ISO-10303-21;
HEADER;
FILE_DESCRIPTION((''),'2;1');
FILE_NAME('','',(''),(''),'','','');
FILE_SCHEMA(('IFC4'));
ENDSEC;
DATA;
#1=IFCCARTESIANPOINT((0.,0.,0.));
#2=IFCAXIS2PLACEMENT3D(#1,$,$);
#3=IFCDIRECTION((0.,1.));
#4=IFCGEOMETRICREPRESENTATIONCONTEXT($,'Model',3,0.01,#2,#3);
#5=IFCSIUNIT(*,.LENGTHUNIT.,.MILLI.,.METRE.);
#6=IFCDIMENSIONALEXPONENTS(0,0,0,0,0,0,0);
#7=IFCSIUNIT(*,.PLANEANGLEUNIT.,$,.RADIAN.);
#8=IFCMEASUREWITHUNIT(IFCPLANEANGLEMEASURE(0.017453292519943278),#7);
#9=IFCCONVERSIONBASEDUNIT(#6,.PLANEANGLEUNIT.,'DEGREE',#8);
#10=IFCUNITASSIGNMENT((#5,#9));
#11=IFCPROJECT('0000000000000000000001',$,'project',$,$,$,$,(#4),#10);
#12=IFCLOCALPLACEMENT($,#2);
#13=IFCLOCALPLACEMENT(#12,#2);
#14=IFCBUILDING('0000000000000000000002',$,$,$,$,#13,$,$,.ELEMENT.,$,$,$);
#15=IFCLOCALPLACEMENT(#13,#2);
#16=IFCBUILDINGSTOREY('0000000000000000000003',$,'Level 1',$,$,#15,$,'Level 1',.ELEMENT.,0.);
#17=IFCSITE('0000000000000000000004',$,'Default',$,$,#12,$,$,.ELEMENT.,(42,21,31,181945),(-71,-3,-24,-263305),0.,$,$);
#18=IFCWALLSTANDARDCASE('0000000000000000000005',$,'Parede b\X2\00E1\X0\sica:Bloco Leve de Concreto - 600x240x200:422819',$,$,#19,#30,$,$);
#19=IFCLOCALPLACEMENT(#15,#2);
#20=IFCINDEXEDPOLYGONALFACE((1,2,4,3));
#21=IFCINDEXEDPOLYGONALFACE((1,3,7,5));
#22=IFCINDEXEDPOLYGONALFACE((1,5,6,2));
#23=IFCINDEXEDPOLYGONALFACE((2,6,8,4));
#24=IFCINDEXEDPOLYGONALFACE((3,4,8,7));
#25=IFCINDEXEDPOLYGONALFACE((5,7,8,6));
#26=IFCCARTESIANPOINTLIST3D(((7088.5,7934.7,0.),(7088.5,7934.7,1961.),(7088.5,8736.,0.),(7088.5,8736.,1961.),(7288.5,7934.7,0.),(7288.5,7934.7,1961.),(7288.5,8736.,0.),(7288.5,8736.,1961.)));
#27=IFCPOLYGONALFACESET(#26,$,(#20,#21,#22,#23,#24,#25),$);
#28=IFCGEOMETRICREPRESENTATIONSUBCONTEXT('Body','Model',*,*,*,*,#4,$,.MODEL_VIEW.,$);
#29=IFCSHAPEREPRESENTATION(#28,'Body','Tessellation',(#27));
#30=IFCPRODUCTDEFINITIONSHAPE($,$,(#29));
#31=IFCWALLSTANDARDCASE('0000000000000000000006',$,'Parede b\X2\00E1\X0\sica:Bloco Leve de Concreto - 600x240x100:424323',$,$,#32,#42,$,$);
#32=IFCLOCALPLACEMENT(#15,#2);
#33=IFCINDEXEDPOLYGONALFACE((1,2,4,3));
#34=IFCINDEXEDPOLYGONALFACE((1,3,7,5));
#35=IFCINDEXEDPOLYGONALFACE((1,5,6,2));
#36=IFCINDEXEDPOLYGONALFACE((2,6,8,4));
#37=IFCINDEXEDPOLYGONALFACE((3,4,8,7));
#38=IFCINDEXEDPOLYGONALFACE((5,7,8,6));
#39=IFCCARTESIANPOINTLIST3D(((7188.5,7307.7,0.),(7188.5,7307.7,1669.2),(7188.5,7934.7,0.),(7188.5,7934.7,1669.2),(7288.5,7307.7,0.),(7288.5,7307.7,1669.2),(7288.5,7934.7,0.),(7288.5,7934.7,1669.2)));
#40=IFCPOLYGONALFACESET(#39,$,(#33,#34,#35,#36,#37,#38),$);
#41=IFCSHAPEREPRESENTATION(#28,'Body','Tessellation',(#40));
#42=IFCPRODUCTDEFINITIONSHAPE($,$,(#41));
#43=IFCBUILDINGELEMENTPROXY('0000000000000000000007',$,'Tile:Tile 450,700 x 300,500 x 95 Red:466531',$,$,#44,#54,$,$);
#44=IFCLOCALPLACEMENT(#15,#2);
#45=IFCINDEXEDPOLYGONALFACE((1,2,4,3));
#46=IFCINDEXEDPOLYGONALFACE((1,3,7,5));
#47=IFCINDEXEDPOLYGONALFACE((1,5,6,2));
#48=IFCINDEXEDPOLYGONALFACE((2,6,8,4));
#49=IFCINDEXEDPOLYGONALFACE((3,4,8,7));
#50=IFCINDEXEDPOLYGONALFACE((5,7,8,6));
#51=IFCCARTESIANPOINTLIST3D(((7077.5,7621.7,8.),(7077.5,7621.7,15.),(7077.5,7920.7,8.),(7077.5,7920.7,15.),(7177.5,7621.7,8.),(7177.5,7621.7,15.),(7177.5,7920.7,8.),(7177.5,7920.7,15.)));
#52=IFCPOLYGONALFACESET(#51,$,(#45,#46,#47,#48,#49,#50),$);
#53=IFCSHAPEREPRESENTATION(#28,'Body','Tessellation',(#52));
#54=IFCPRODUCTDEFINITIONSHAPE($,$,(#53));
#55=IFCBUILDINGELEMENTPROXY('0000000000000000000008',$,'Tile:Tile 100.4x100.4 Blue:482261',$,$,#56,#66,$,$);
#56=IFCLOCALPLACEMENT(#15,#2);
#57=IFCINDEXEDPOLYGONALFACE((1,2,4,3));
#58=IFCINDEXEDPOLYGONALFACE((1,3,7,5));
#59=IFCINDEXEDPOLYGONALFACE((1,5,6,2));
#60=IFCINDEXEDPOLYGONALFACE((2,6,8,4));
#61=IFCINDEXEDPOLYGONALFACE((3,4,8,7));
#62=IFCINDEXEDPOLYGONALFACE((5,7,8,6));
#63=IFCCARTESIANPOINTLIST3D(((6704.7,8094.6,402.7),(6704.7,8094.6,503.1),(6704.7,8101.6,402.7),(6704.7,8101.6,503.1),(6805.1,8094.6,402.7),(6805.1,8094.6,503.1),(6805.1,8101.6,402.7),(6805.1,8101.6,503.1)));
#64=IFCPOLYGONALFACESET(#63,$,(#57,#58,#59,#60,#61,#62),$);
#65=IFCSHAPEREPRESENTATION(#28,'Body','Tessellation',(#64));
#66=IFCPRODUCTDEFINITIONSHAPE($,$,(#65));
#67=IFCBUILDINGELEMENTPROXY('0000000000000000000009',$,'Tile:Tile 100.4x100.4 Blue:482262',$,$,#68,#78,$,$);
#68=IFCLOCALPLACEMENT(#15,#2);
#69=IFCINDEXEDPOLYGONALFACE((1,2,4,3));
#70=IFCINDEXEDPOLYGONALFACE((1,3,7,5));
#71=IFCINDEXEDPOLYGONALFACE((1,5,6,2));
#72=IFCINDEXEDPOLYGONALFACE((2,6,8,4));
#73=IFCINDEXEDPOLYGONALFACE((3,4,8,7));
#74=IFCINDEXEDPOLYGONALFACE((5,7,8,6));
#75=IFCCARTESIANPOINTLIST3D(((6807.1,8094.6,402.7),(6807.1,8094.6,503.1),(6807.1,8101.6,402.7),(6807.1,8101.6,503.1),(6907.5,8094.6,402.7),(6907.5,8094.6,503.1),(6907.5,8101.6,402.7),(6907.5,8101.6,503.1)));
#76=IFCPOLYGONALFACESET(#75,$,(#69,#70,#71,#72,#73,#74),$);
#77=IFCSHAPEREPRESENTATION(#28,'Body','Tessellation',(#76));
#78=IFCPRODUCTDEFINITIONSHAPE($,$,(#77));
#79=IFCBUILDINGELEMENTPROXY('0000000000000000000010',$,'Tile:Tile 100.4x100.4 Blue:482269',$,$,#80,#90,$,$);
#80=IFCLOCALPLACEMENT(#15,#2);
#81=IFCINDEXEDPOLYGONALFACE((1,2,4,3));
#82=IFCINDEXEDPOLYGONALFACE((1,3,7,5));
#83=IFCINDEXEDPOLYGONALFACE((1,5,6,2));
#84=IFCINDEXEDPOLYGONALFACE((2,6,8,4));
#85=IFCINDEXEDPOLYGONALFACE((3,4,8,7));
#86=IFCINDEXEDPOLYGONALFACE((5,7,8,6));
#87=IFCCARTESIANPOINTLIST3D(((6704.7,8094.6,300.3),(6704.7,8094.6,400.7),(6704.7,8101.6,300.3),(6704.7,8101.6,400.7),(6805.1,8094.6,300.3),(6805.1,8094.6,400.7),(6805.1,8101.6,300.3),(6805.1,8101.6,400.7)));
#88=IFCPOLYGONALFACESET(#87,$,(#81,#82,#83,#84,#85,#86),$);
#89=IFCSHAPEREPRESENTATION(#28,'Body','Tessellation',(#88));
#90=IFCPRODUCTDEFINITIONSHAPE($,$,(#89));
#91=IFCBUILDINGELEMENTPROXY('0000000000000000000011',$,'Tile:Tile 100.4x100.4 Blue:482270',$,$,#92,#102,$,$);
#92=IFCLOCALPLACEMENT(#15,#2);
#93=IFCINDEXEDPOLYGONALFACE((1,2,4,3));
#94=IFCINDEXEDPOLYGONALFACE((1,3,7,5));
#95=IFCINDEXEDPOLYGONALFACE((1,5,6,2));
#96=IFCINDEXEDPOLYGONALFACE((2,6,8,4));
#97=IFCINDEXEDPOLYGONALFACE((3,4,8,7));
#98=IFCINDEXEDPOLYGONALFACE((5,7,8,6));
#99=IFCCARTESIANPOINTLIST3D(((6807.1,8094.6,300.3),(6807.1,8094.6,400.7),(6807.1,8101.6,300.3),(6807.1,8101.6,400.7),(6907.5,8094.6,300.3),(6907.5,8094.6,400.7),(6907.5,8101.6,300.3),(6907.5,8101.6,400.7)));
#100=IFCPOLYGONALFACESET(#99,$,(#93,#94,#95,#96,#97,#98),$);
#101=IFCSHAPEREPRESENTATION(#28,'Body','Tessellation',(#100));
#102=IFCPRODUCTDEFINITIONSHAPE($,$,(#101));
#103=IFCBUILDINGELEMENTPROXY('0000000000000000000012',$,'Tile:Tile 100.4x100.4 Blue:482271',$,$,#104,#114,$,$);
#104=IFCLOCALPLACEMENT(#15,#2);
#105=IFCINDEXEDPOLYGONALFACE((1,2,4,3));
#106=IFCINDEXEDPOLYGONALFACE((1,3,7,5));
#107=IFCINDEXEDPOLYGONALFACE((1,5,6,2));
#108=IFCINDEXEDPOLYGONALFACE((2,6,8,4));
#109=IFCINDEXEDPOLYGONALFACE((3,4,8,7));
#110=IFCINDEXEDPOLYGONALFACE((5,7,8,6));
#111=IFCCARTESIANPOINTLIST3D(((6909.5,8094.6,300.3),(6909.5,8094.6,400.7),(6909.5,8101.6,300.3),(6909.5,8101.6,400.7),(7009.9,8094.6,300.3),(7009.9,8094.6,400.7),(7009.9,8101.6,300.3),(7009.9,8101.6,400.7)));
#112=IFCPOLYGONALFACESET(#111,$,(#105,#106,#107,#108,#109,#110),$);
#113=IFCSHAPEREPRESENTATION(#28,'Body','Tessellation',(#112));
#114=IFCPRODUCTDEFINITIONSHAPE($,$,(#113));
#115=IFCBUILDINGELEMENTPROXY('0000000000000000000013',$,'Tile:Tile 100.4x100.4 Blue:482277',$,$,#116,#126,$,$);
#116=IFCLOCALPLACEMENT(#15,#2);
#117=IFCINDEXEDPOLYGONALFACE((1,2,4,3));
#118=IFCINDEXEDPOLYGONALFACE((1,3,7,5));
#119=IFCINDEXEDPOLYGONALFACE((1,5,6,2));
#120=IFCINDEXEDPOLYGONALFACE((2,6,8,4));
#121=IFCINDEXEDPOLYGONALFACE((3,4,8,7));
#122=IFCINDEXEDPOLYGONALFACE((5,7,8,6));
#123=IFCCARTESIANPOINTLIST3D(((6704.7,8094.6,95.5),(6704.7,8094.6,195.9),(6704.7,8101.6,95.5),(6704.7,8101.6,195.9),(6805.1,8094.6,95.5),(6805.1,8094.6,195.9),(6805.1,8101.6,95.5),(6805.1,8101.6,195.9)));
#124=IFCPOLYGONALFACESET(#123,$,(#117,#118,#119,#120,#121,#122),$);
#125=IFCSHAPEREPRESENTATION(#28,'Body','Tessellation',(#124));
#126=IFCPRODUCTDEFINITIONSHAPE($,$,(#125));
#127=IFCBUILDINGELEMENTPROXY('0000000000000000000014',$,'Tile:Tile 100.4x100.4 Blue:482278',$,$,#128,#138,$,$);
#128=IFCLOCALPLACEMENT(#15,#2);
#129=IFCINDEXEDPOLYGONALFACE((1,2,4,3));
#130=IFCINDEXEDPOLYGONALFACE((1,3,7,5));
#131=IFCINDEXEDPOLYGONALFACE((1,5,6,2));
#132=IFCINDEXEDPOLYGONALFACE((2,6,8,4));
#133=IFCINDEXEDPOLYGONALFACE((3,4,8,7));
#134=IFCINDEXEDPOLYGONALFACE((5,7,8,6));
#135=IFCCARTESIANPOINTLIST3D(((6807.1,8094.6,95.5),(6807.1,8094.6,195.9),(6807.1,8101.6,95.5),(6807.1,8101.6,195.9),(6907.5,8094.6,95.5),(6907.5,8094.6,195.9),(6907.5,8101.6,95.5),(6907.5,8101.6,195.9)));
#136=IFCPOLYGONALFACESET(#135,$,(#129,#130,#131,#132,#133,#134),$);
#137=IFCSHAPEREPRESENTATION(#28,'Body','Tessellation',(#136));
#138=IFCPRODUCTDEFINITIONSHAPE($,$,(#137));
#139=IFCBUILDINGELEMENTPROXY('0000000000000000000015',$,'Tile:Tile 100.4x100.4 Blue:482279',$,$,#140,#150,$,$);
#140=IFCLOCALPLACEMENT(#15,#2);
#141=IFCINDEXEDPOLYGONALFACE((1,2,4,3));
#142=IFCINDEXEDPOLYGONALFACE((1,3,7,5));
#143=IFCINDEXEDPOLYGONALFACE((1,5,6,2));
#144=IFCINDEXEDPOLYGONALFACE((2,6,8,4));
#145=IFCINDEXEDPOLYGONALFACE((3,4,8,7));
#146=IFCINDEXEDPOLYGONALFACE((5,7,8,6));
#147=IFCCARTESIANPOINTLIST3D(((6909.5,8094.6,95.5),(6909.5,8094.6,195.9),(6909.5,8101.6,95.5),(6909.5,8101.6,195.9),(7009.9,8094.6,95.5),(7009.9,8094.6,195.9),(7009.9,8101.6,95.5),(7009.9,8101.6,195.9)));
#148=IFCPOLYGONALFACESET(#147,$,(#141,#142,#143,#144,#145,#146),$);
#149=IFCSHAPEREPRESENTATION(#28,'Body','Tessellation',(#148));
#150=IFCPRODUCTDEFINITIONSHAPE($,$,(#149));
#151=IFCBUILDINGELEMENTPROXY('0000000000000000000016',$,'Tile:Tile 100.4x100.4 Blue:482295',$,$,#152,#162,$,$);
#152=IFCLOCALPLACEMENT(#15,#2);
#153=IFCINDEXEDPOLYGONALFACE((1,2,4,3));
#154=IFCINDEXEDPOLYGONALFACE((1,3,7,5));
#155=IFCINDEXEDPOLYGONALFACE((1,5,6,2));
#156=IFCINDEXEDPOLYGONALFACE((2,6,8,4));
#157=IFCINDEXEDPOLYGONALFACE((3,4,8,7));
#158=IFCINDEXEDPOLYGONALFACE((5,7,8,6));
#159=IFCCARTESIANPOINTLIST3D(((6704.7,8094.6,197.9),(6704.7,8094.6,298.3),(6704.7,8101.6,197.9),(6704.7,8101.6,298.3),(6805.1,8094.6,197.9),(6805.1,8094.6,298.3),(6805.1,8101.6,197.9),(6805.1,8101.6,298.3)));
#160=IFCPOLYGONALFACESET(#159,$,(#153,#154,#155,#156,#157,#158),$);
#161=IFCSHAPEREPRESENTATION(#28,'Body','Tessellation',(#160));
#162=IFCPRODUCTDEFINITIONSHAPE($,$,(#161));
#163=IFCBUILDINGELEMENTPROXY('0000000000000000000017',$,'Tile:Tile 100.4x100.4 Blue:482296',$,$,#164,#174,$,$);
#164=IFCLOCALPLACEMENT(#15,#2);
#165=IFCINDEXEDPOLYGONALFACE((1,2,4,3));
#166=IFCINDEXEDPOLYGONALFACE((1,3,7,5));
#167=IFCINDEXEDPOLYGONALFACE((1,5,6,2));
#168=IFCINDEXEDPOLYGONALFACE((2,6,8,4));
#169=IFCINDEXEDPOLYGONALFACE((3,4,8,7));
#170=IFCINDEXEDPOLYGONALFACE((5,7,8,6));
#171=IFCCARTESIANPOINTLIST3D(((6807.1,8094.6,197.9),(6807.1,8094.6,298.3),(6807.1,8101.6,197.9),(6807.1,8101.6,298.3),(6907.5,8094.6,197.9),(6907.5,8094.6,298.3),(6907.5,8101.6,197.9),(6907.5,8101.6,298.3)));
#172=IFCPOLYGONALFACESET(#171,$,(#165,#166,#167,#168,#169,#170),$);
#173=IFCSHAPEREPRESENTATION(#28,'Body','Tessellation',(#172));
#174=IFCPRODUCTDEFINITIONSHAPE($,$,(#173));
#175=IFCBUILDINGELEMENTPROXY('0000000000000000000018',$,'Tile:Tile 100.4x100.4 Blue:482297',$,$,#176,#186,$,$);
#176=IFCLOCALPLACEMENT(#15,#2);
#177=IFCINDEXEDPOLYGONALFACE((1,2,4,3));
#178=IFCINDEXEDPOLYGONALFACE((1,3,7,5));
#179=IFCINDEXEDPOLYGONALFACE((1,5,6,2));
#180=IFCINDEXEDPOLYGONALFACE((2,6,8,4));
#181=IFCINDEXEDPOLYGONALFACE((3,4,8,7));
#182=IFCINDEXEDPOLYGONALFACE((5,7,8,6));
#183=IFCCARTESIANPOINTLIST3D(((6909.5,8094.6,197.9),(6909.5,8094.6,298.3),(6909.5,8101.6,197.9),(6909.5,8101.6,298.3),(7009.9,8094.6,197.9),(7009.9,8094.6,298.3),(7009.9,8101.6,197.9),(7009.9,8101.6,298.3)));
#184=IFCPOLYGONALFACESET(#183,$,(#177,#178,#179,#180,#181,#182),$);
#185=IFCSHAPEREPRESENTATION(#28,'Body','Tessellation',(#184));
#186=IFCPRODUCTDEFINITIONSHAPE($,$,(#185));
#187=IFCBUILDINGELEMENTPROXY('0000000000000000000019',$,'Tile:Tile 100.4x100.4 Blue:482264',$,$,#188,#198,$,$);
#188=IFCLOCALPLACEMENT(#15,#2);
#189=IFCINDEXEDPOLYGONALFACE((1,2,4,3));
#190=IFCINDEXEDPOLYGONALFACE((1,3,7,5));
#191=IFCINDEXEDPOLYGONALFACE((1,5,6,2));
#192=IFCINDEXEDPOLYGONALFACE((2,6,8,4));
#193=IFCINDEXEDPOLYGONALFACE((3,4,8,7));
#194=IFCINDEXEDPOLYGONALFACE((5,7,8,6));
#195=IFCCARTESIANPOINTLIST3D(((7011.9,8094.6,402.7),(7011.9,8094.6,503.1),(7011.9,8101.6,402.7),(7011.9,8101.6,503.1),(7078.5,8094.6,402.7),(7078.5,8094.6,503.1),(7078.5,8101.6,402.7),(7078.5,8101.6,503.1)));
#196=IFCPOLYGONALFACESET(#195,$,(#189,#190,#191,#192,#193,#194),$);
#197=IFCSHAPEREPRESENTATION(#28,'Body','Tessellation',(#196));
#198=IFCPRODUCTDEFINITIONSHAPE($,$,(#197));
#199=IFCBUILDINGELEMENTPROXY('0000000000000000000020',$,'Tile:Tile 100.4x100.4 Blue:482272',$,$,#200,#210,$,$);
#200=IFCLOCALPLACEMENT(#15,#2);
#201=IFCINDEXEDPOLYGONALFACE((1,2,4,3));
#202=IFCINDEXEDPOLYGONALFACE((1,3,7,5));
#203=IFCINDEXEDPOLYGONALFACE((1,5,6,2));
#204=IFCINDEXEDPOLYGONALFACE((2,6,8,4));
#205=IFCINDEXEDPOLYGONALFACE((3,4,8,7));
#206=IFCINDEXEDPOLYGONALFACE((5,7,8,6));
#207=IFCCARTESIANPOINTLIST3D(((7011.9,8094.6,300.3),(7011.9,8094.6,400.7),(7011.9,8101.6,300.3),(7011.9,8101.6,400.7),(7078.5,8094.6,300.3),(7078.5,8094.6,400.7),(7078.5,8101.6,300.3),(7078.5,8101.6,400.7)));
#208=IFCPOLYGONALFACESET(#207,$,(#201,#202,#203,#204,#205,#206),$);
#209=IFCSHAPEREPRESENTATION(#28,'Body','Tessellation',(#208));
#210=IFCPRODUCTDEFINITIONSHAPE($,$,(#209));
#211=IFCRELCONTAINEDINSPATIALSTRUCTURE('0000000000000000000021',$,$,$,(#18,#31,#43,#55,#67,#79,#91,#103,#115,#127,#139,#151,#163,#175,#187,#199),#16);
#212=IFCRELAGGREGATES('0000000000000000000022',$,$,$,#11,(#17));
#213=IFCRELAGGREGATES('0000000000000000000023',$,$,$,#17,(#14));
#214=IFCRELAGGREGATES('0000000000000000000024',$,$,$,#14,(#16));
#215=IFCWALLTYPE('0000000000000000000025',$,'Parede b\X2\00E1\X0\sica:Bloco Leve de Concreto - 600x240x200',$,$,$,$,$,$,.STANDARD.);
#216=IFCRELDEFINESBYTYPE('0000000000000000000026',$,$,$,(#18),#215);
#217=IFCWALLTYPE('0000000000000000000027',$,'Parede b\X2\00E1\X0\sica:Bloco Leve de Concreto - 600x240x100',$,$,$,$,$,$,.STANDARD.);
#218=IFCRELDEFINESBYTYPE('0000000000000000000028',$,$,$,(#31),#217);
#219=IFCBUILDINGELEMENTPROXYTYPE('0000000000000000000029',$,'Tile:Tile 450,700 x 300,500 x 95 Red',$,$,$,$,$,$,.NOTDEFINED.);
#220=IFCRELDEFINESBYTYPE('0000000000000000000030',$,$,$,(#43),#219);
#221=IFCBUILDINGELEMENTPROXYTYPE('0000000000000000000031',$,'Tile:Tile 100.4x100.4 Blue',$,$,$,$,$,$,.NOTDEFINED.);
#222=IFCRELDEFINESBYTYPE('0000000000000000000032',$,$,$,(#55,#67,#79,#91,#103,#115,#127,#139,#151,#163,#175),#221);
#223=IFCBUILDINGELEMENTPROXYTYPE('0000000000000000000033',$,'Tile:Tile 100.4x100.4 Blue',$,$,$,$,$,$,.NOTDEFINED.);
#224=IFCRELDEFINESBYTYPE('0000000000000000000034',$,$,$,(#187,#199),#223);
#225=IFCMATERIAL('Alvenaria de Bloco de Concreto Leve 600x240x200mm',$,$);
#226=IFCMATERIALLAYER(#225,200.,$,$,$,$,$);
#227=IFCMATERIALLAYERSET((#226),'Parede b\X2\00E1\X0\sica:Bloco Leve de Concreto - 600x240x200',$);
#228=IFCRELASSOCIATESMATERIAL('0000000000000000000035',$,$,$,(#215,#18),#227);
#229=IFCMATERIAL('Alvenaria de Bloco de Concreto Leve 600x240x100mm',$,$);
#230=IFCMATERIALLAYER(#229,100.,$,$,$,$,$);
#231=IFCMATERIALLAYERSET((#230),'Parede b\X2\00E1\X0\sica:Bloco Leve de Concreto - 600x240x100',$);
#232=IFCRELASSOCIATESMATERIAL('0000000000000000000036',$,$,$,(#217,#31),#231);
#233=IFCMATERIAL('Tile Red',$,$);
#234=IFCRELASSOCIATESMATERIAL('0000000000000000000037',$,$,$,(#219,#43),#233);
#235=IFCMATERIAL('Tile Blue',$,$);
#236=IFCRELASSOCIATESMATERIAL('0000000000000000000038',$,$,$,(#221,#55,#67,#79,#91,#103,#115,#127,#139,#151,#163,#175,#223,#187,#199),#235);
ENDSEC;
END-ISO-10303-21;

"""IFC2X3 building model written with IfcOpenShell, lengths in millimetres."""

from ifc_helpers import new_model, entity, si_unit, converted_unit, direction, frame, frame_2d, origin, origin_2d_with_axis, place, context, subcontext, project, spatial, rectangle, extrude, source, transform, mapped, material, layer, layer_set, layer_usage, type_object, type_shapes, element, save


model = new_model("IFC2X3")

# Units and contexts
model_context = context("Model", 3, precision=0.01, world=origin(), true_north=direction((0.0, 1.0)))
body_context = subcontext(model_context, "Body", "Model", "MODEL_VIEW")
ifc_project = project(units=[si_unit("LENGTHUNIT", "METRE", prefix="MILLI"), converted_unit("PLANEANGLEUNIT", "DEGREE", entity("IfcPlaneAngleMeasure", 0.017453292519943278), si_unit("PLANEANGLEUNIT", "RADIAN"), dimensions=[0, 0, 0, 0, 0, 0, 0])], contexts=[model_context])

# Site, building, storey
site_placement = place(None, origin())
site = spatial("IfcSite", under=ifc_project, at=site_placement, Name="Default", CompositionType="ELEMENT", RefLatitude=(42, 21, 31, 181945), RefLongitude=(-71, -3, -24, -263305), RefElevation=0.0)
building_placement = place(site_placement, origin())
building = spatial("IfcBuilding", under=site, at=building_placement, CompositionType="ELEMENT")
storey_placement = place(building_placement, origin())
storey = spatial("IfcBuildingStorey", under=building, at=storey_placement, Name="Level 1", LongName="Level 1", CompositionType="ELEMENT", Elevation=0.0)

# Walls
ifc_material_1 = material(Name="Alvenaria de Bloco de Concreto Leve 600x240x200mm")
ifc_layer_1 = layer(ifc_material_1, 200.0)
ifc_layer_set_1 = layer_set([ifc_layer_1], Name="Parede básica:Bloco Leve de Concreto - 600x240x200")
ifc_layer_usage_1 = layer_usage(ifc_layer_set_1, "AXIS2", "NEGATIVE", 100.0)
wall_type_1 = type_object("IfcWallType", Name="Parede básica:Bloco Leve de Concreto - 600x240x200", PredefinedType="STANDARD", material=ifc_layer_set_1)
wall_1_placement = place(storey_placement, frame((7188.5, 8736.0, 0.0), z_axis=(0.0, 0.0, 1.0), x_axis=(0.0, -1.0, 0.0)))
element("IfcWallStandardCase", 1, at=wall_1_placement, inside=storey, type_object=wall_type_1, material=ifc_layer_usage_1, Name="Parede básica:Bloco Leve de Concreto - 600x240x200:422819", context=body_context, shape_type="SweptSolid", body=[
    extrude(rectangle(XDim=801.4, YDim=200.0, at=frame_2d((400.7, 0.0), x_axis=(-1.0, 0.0))), origin(), (0.0, 0.0, 1.0), 1961.0),
])
ifc_material_2 = material(Name="Alvenaria de Bloco de Concreto Leve 600x240x100mm")
ifc_layer_2 = layer(ifc_material_2, 100.0)
ifc_layer_set_2 = layer_set([ifc_layer_2], Name="Parede básica:Bloco Leve de Concreto - 600x240x100")
ifc_layer_usage_2 = layer_usage(ifc_layer_set_2, "AXIS2", "NEGATIVE", 50.0)
wall_type_2 = type_object("IfcWallType", Name="Parede básica:Bloco Leve de Concreto - 600x240x100", PredefinedType="STANDARD", material=ifc_layer_set_2)
wall_2_placement = place(storey_placement, frame((7238.5, 7934.7, 0.0), z_axis=(0.0, 0.0, 1.0), x_axis=(0.0, -1.0, 0.0)))
element("IfcWallStandardCase", 2, at=wall_2_placement, inside=storey, type_object=wall_type_2, material=ifc_layer_usage_2, Name="Parede básica:Bloco Leve de Concreto - 600x240x100:424323", context=body_context, shape_type="SweptSolid", body=[
    extrude(rectangle(XDim=627.0, YDim=100.0, at=frame_2d((313.5, 0.0), x_axis=(-1.0, 0.0))), origin(), (0.0, 0.0, 1.0), 1669.2),
])

# Building element proxies
ifc_material_3 = material(Name="Tile Red")
building_element_proxy_type_1 = type_object("IfcBuildingElementProxyType", Name="Tile:Tile 450,700 x 300,500 x 95 Red", PredefinedType="NOTDEFINED", material=ifc_material_3)
shared_shape_1 = source(origin(), body_context, "Body", "SweptSolid", [
    extrude(rectangle(XDim=100.0, YDim=299.0, at=origin_2d_with_axis()), frame((-50.0, -149.5, 0.0), z_axis=(0.0, 0.0, 1.0), x_axis=(-1.0, 0.0, 0.0)), (0.0, 0.0, 1.0), 7.0),
])
type_shapes(building_element_proxy_type_1, [shared_shape_1])
proxy_1_placement = place(storey_placement, frame((7177.5, 7920.7, 8.0)))
element("IfcBuildingElementProxy", 3, at=proxy_1_placement, inside=storey, type_object=building_element_proxy_type_1, material=ifc_material_3, Name="Tile:Tile 450,700 x 300,500 x 95 Red:466531", context=body_context, shape_type="MappedRepresentation", body=[
    mapped(shared_shape_1, transform((0.0, 0.0, 0.0), scale=1.0)),
])
ifc_material_4 = material(Name="Tile Blue")
building_element_proxy_type_2 = type_object("IfcBuildingElementProxyType", Name="Tile:Tile 100.4x100.4 Blue", PredefinedType="NOTDEFINED", material=ifc_material_4)
shared_shape_2 = source(origin(), body_context, "Body", "SweptSolid", [
    extrude(rectangle(XDim=100.4, YDim=100.4, at=origin_2d_with_axis()), frame((-50.2, -50.2, 0.0), z_axis=(0.0, 0.0, 1.0), x_axis=(0.0, -1.0, 0.0)), (0.0, 0.0, 1.0), 7.0),
])
type_shapes(building_element_proxy_type_2, [shared_shape_2])
for number, where, z_axis, x_axis, name in (
    (4, (6704.7, 8101.6, 402.7), (0.0, -1.0, 0.0), (-1.0, 0.0, 0.0), "Tile:Tile 100.4x100.4 Blue:482261"),
    (5, (6807.1, 8101.6, 402.7), (0.0, -1.0, 0.0), (-1.0, 0.0, 0.0), "Tile:Tile 100.4x100.4 Blue:482262"),
    (6, (6704.7, 8101.6, 300.3), (0.0, -1.0, 0.0), (-1.0, 0.0, 0.0), "Tile:Tile 100.4x100.4 Blue:482269"),
    (7, (6807.1, 8101.6, 300.3), (0.0, -1.0, 0.0), (-1.0, 0.0, 0.0), "Tile:Tile 100.4x100.4 Blue:482270"),
    (8, (6909.5, 8101.6, 300.3), (0.0, -1.0, 0.0), (-1.0, 0.0, 0.0), "Tile:Tile 100.4x100.4 Blue:482271"),
    (9, (6704.7, 8101.6, 95.5), (0.0, -1.0, 0.0), (-1.0, 0.0, 0.0), "Tile:Tile 100.4x100.4 Blue:482277"),
    (10, (6807.1, 8101.6, 95.5), (0.0, -1.0, 0.0), (-1.0, 0.0, 0.0), "Tile:Tile 100.4x100.4 Blue:482278"),
    (11, (6909.5, 8101.6, 95.5), (0.0, -1.0, 0.0), (-1.0, 0.0, 0.0), "Tile:Tile 100.4x100.4 Blue:482279"),
    (12, (6704.7, 8101.6, 197.9), (0.0, -1.0, 0.0), (-1.0, 0.0, 0.0), "Tile:Tile 100.4x100.4 Blue:482295"),
    (13, (6807.1, 8101.6, 197.9), (0.0, -1.0, 0.0), (-1.0, 0.0, 0.0), "Tile:Tile 100.4x100.4 Blue:482296"),
    (14, (6909.5, 8101.6, 197.9), (0.0, -1.0, 0.0), (-1.0, 0.0, 0.0), "Tile:Tile 100.4x100.4 Blue:482297"),
):
    element("IfcBuildingElementProxy", number, at=place(storey_placement, frame(where, z_axis=z_axis, x_axis=x_axis)), inside=storey, type_object=building_element_proxy_type_2, material=ifc_material_4, Name=name, context=body_context, shape_type="MappedRepresentation", body=[
        mapped(shared_shape_2, transform((0.0, 0.0, 0.0), scale=1.0)),
    ])
building_element_proxy_type_3 = type_object("IfcBuildingElementProxyType", Name="Tile:Tile 100.4x100.4 Blue", PredefinedType="NOTDEFINED", material=ifc_material_4)
shared_shape_3 = source(origin(), body_context, "Body", "SweptSolid", [
    extrude(rectangle(XDim=66.6, YDim=100.4, at=origin_2d_with_axis()), frame((-33.3, -50.2, 0.0), z_axis=(0.0, 0.0, 1.0), x_axis=(-1.0, 0.0, 0.0)), (0.0, 0.0, 1.0), 7.0),
])
type_shapes(building_element_proxy_type_3, [shared_shape_3])
for number, where, z_axis, x_axis, name in (
    (15, (7011.9, 8101.6, 402.7), (0.0, -1.0, 0.0), (-1.0, 0.0, 0.0), "Tile:Tile 100.4x100.4 Blue:482264"),
    (16, (7011.9, 8101.6, 300.3), (0.0, -1.0, 0.0), (-1.0, 0.0, 0.0), "Tile:Tile 100.4x100.4 Blue:482272"),
):
    element("IfcBuildingElementProxy", number, at=place(storey_placement, frame(where, z_axis=z_axis, x_axis=x_axis)), inside=storey, type_object=building_element_proxy_type_3, material=ifc_material_4, Name=name, context=body_context, shape_type="MappedRepresentation", body=[
        mapped(shared_shape_3, transform((0.0, 0.0, 0.0), scale=1.0)),
    ])

save(model, "model.ifc")
